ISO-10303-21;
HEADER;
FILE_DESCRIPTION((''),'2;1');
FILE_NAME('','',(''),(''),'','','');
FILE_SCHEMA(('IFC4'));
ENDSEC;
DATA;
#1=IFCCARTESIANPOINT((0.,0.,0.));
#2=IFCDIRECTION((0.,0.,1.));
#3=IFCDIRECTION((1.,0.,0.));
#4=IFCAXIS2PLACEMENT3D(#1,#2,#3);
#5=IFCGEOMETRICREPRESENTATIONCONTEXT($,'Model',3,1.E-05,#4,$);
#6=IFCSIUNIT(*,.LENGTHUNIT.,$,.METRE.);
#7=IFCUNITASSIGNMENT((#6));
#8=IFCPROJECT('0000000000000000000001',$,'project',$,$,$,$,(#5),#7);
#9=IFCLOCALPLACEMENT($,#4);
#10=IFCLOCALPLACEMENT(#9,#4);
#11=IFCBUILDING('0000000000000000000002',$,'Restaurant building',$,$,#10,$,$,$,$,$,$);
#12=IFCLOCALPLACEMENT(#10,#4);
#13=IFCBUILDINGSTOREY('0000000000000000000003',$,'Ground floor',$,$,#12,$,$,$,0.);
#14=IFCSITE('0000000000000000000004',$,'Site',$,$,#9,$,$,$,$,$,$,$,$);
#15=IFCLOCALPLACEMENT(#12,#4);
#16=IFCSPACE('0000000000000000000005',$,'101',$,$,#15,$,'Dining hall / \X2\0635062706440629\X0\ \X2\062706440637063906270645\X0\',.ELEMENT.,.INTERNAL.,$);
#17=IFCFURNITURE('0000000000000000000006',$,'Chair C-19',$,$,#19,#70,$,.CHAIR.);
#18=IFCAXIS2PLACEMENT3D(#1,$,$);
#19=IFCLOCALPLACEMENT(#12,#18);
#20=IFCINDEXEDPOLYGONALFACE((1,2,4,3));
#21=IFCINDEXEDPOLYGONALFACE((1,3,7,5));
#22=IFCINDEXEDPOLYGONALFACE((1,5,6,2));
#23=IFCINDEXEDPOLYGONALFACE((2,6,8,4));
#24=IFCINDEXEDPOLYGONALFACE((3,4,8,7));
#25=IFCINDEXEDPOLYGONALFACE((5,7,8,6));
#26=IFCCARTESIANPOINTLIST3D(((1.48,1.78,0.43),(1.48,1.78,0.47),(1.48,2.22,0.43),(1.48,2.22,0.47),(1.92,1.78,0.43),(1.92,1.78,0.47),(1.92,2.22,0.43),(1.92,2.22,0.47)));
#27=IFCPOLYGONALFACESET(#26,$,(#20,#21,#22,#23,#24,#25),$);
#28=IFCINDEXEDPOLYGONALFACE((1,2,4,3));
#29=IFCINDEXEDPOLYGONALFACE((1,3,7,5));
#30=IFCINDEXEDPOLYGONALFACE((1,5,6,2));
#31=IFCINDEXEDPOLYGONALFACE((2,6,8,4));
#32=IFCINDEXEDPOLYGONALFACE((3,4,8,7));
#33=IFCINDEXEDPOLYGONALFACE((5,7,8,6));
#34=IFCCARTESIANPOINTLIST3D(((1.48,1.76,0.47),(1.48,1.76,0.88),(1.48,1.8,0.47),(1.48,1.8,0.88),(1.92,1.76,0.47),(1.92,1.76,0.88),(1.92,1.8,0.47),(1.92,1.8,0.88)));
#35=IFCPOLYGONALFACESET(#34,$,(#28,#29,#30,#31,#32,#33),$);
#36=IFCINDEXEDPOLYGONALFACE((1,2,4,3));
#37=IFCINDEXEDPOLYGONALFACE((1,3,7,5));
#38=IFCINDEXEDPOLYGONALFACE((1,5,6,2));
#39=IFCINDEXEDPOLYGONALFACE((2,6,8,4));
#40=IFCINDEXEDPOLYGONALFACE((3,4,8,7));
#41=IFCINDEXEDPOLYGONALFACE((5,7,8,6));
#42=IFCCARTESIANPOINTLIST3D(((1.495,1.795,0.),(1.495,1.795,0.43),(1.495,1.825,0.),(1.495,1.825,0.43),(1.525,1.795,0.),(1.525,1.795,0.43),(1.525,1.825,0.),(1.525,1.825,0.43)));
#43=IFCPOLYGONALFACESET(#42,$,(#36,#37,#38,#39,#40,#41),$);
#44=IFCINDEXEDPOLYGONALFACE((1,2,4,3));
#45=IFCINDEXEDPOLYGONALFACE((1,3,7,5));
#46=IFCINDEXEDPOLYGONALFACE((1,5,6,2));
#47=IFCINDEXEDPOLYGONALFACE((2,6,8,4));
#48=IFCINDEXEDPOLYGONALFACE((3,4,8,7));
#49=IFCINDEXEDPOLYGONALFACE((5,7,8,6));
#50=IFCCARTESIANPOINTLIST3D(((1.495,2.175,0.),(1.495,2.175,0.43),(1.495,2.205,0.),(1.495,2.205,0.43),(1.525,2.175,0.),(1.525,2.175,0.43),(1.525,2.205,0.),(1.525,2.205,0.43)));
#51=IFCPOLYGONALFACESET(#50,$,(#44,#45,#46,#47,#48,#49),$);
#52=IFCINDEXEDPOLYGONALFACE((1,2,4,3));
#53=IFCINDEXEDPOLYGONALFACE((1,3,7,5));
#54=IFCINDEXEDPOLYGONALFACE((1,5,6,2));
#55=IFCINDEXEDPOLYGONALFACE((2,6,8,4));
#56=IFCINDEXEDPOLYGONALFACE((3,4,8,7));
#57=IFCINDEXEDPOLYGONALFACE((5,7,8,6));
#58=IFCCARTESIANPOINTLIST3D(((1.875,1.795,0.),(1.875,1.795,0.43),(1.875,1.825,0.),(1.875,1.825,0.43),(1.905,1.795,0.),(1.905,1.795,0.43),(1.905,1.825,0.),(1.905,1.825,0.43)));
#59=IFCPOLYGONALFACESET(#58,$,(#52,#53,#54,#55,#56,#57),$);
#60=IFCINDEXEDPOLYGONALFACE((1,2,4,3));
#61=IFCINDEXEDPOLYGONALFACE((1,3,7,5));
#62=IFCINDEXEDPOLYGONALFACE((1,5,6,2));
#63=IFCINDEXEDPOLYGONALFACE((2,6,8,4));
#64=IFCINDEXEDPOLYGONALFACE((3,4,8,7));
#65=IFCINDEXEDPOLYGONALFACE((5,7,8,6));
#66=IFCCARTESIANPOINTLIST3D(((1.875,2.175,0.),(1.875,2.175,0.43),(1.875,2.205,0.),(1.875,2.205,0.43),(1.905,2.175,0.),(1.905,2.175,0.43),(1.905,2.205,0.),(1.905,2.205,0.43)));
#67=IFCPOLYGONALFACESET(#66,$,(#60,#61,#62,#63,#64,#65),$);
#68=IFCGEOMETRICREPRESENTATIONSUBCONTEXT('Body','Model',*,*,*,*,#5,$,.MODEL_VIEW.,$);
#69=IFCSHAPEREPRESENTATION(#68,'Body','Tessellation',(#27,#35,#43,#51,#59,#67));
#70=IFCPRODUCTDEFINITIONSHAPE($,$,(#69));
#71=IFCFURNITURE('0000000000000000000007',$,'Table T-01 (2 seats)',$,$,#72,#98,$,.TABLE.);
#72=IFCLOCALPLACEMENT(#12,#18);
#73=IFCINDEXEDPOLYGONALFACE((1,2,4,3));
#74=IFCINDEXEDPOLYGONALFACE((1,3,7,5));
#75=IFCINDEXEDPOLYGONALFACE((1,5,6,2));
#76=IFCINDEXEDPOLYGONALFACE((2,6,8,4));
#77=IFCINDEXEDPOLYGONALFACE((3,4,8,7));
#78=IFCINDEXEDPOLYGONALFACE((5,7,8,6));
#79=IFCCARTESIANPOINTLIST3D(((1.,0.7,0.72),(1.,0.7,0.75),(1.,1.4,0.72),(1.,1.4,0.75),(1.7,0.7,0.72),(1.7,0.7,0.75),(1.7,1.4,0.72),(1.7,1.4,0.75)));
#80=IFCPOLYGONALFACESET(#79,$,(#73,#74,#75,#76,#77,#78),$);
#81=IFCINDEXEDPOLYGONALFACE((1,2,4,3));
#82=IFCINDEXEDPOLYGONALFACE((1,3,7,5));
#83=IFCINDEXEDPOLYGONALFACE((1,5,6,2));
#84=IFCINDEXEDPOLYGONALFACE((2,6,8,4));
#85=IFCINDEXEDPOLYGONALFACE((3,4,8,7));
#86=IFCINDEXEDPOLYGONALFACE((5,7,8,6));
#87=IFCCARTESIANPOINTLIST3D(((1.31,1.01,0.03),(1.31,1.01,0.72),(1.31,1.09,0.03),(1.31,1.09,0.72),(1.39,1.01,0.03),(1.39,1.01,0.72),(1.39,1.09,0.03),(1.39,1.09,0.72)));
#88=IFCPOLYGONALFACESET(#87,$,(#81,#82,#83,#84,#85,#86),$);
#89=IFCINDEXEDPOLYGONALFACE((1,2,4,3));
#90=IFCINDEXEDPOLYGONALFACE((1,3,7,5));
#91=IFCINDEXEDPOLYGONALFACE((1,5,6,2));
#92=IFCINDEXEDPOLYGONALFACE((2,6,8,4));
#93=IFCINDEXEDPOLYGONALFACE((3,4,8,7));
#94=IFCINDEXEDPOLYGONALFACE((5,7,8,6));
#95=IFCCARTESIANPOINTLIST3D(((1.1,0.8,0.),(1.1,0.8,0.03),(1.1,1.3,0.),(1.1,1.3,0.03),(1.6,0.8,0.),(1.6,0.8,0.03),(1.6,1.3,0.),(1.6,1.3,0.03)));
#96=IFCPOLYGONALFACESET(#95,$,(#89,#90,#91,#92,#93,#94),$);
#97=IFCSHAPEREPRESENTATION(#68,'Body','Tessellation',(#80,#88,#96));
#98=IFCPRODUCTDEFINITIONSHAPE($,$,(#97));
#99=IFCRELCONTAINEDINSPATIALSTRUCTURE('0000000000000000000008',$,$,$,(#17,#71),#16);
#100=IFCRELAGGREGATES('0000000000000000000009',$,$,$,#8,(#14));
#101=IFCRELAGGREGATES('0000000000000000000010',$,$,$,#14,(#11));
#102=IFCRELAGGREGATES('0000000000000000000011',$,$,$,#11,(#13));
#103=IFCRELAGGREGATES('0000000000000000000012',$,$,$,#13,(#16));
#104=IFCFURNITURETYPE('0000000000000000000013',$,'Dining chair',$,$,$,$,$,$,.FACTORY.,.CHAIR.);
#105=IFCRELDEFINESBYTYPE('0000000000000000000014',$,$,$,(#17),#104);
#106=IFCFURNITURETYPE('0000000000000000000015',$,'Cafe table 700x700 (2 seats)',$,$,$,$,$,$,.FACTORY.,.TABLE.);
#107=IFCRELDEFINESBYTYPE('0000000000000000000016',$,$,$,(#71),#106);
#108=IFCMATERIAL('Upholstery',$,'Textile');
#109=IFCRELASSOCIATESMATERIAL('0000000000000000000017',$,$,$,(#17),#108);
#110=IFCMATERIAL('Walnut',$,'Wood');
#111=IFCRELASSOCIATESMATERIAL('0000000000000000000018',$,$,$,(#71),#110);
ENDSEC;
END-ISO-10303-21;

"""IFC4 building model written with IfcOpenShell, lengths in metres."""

from ifc_helpers import new_model, si_unit, frame, origin, origin_with_axes, origin_2d, place, context, subcontext, project, spatial, rectangle, extrude, source, transform, mapped, material, type_object, type_shapes, element, save


model = new_model("IFC4")

# Units and contexts
model_context = context("Model", 3, precision=1e-05, world=origin_with_axes())
body_context = subcontext(model_context, "Body", "Model", "MODEL_VIEW")
ifc_project = project(units=[si_unit("LENGTHUNIT", "METRE")], contexts=[model_context])

# Site, building, storey
site_placement = place(None, origin_with_axes())
site = spatial("IfcSite", under=ifc_project, at=site_placement, Name="Site")
building_placement = place(site_placement, origin_with_axes())
building = spatial("IfcBuilding", under=site, at=building_placement, Name="Restaurant building")
storey_placement = place(building_placement, origin_with_axes())
storey = spatial("IfcBuildingStorey", under=building, at=storey_placement, Name="Ground floor", Elevation=0.0)

# Shared definitions
space_1_placement = place(storey_placement, origin_with_axes())
space_1 = spatial("IfcSpace", under=storey, at=space_1_placement, Name="101", LongName="Dining hall / صالة الطعام", CompositionType="ELEMENT", PredefinedType="INTERNAL")

# Furniture
ifc_material_1 = material(Name="Upholstery", Category="Textile")
furniture_type_1 = type_object("IfcFurnitureType", Name="Dining chair", AssemblyPlace="FACTORY", PredefinedType="CHAIR")
shared_shape_1 = source(origin(), body_context, "Body", "SweptSolid", [
    extrude(rectangle(XDim=0.44, YDim=0.44, at=origin_2d()), frame((0.0, 0.0, 0.43)), (0.0, 0.0, 1.0), 0.04),
    extrude(rectangle(XDim=0.44, YDim=0.04, at=origin_2d()), frame((0.0, -0.22, 0.47)), (0.0, 0.0, 1.0), 0.41),
    extrude(rectangle(XDim=0.03, YDim=0.03, at=origin_2d()), frame((-0.19, -0.19, 0.0)), (0.0, 0.0, 1.0), 0.43),
    extrude(rectangle(XDim=0.03, YDim=0.03, at=origin_2d()), frame((-0.19, 0.19, 0.0)), (0.0, 0.0, 1.0), 0.43),
    extrude(rectangle(XDim=0.03, YDim=0.03, at=origin_2d()), frame((0.19, -0.19, 0.0)), (0.0, 0.0, 1.0), 0.43),
    extrude(rectangle(XDim=0.03, YDim=0.03, at=origin_2d()), frame((0.19, 0.19, 0.0)), (0.0, 0.0, 1.0), 0.43),
])
type_shapes(furniture_type_1, [shared_shape_1])
for number, where, name in (
    (1, (1.7, 2.0, 0.0), "Chair C-19"),
):
    element("IfcFurniture", number, at=place(storey_placement, frame(where)), inside=space_1, type_object=furniture_type_1, material=ifc_material_1, Name=name, PredefinedType="CHAIR", context=body_context, shape_type="MappedRepresentation", body=[
        mapped(shared_shape_1, transform((0.0, 0.0, 0.0))),
    ])
ifc_material_2 = material(Name="Walnut", Category="Wood")
furniture_type_2 = type_object("IfcFurnitureType", Name="Cafe table 700x700 (2 seats)", AssemblyPlace="FACTORY", PredefinedType="TABLE")
shared_shape_2 = source(origin(), body_context, "Body", "SweptSolid", [
    extrude(rectangle(XDim=0.7, YDim=0.7, at=origin_2d()), frame((0.0, 0.0, 0.72)), (0.0, 0.0, 1.0), 0.03),
    extrude(rectangle(XDim=0.08, YDim=0.08, at=origin_2d()), frame((0.0, 0.0, 0.03)), (0.0, 0.0, 1.0), 0.69),
    extrude(rectangle(XDim=0.5, YDim=0.5, at=origin_2d()), origin(), (0.0, 0.0, 1.0), 0.03),
])
type_shapes(furniture_type_2, [shared_shape_2])
furniture_1_placement = place(storey_placement, frame((1.35, 1.05, 0.0)))
element("IfcFurniture", 2, at=furniture_1_placement, inside=space_1, type_object=furniture_type_2, material=ifc_material_2, Name="Table T-01 (2 seats)", PredefinedType="TABLE", context=body_context, shape_type="MappedRepresentation", body=[
    mapped(shared_shape_2, transform((0.0, 0.0, 0.0))),
])

save(model, "model.ifc")
